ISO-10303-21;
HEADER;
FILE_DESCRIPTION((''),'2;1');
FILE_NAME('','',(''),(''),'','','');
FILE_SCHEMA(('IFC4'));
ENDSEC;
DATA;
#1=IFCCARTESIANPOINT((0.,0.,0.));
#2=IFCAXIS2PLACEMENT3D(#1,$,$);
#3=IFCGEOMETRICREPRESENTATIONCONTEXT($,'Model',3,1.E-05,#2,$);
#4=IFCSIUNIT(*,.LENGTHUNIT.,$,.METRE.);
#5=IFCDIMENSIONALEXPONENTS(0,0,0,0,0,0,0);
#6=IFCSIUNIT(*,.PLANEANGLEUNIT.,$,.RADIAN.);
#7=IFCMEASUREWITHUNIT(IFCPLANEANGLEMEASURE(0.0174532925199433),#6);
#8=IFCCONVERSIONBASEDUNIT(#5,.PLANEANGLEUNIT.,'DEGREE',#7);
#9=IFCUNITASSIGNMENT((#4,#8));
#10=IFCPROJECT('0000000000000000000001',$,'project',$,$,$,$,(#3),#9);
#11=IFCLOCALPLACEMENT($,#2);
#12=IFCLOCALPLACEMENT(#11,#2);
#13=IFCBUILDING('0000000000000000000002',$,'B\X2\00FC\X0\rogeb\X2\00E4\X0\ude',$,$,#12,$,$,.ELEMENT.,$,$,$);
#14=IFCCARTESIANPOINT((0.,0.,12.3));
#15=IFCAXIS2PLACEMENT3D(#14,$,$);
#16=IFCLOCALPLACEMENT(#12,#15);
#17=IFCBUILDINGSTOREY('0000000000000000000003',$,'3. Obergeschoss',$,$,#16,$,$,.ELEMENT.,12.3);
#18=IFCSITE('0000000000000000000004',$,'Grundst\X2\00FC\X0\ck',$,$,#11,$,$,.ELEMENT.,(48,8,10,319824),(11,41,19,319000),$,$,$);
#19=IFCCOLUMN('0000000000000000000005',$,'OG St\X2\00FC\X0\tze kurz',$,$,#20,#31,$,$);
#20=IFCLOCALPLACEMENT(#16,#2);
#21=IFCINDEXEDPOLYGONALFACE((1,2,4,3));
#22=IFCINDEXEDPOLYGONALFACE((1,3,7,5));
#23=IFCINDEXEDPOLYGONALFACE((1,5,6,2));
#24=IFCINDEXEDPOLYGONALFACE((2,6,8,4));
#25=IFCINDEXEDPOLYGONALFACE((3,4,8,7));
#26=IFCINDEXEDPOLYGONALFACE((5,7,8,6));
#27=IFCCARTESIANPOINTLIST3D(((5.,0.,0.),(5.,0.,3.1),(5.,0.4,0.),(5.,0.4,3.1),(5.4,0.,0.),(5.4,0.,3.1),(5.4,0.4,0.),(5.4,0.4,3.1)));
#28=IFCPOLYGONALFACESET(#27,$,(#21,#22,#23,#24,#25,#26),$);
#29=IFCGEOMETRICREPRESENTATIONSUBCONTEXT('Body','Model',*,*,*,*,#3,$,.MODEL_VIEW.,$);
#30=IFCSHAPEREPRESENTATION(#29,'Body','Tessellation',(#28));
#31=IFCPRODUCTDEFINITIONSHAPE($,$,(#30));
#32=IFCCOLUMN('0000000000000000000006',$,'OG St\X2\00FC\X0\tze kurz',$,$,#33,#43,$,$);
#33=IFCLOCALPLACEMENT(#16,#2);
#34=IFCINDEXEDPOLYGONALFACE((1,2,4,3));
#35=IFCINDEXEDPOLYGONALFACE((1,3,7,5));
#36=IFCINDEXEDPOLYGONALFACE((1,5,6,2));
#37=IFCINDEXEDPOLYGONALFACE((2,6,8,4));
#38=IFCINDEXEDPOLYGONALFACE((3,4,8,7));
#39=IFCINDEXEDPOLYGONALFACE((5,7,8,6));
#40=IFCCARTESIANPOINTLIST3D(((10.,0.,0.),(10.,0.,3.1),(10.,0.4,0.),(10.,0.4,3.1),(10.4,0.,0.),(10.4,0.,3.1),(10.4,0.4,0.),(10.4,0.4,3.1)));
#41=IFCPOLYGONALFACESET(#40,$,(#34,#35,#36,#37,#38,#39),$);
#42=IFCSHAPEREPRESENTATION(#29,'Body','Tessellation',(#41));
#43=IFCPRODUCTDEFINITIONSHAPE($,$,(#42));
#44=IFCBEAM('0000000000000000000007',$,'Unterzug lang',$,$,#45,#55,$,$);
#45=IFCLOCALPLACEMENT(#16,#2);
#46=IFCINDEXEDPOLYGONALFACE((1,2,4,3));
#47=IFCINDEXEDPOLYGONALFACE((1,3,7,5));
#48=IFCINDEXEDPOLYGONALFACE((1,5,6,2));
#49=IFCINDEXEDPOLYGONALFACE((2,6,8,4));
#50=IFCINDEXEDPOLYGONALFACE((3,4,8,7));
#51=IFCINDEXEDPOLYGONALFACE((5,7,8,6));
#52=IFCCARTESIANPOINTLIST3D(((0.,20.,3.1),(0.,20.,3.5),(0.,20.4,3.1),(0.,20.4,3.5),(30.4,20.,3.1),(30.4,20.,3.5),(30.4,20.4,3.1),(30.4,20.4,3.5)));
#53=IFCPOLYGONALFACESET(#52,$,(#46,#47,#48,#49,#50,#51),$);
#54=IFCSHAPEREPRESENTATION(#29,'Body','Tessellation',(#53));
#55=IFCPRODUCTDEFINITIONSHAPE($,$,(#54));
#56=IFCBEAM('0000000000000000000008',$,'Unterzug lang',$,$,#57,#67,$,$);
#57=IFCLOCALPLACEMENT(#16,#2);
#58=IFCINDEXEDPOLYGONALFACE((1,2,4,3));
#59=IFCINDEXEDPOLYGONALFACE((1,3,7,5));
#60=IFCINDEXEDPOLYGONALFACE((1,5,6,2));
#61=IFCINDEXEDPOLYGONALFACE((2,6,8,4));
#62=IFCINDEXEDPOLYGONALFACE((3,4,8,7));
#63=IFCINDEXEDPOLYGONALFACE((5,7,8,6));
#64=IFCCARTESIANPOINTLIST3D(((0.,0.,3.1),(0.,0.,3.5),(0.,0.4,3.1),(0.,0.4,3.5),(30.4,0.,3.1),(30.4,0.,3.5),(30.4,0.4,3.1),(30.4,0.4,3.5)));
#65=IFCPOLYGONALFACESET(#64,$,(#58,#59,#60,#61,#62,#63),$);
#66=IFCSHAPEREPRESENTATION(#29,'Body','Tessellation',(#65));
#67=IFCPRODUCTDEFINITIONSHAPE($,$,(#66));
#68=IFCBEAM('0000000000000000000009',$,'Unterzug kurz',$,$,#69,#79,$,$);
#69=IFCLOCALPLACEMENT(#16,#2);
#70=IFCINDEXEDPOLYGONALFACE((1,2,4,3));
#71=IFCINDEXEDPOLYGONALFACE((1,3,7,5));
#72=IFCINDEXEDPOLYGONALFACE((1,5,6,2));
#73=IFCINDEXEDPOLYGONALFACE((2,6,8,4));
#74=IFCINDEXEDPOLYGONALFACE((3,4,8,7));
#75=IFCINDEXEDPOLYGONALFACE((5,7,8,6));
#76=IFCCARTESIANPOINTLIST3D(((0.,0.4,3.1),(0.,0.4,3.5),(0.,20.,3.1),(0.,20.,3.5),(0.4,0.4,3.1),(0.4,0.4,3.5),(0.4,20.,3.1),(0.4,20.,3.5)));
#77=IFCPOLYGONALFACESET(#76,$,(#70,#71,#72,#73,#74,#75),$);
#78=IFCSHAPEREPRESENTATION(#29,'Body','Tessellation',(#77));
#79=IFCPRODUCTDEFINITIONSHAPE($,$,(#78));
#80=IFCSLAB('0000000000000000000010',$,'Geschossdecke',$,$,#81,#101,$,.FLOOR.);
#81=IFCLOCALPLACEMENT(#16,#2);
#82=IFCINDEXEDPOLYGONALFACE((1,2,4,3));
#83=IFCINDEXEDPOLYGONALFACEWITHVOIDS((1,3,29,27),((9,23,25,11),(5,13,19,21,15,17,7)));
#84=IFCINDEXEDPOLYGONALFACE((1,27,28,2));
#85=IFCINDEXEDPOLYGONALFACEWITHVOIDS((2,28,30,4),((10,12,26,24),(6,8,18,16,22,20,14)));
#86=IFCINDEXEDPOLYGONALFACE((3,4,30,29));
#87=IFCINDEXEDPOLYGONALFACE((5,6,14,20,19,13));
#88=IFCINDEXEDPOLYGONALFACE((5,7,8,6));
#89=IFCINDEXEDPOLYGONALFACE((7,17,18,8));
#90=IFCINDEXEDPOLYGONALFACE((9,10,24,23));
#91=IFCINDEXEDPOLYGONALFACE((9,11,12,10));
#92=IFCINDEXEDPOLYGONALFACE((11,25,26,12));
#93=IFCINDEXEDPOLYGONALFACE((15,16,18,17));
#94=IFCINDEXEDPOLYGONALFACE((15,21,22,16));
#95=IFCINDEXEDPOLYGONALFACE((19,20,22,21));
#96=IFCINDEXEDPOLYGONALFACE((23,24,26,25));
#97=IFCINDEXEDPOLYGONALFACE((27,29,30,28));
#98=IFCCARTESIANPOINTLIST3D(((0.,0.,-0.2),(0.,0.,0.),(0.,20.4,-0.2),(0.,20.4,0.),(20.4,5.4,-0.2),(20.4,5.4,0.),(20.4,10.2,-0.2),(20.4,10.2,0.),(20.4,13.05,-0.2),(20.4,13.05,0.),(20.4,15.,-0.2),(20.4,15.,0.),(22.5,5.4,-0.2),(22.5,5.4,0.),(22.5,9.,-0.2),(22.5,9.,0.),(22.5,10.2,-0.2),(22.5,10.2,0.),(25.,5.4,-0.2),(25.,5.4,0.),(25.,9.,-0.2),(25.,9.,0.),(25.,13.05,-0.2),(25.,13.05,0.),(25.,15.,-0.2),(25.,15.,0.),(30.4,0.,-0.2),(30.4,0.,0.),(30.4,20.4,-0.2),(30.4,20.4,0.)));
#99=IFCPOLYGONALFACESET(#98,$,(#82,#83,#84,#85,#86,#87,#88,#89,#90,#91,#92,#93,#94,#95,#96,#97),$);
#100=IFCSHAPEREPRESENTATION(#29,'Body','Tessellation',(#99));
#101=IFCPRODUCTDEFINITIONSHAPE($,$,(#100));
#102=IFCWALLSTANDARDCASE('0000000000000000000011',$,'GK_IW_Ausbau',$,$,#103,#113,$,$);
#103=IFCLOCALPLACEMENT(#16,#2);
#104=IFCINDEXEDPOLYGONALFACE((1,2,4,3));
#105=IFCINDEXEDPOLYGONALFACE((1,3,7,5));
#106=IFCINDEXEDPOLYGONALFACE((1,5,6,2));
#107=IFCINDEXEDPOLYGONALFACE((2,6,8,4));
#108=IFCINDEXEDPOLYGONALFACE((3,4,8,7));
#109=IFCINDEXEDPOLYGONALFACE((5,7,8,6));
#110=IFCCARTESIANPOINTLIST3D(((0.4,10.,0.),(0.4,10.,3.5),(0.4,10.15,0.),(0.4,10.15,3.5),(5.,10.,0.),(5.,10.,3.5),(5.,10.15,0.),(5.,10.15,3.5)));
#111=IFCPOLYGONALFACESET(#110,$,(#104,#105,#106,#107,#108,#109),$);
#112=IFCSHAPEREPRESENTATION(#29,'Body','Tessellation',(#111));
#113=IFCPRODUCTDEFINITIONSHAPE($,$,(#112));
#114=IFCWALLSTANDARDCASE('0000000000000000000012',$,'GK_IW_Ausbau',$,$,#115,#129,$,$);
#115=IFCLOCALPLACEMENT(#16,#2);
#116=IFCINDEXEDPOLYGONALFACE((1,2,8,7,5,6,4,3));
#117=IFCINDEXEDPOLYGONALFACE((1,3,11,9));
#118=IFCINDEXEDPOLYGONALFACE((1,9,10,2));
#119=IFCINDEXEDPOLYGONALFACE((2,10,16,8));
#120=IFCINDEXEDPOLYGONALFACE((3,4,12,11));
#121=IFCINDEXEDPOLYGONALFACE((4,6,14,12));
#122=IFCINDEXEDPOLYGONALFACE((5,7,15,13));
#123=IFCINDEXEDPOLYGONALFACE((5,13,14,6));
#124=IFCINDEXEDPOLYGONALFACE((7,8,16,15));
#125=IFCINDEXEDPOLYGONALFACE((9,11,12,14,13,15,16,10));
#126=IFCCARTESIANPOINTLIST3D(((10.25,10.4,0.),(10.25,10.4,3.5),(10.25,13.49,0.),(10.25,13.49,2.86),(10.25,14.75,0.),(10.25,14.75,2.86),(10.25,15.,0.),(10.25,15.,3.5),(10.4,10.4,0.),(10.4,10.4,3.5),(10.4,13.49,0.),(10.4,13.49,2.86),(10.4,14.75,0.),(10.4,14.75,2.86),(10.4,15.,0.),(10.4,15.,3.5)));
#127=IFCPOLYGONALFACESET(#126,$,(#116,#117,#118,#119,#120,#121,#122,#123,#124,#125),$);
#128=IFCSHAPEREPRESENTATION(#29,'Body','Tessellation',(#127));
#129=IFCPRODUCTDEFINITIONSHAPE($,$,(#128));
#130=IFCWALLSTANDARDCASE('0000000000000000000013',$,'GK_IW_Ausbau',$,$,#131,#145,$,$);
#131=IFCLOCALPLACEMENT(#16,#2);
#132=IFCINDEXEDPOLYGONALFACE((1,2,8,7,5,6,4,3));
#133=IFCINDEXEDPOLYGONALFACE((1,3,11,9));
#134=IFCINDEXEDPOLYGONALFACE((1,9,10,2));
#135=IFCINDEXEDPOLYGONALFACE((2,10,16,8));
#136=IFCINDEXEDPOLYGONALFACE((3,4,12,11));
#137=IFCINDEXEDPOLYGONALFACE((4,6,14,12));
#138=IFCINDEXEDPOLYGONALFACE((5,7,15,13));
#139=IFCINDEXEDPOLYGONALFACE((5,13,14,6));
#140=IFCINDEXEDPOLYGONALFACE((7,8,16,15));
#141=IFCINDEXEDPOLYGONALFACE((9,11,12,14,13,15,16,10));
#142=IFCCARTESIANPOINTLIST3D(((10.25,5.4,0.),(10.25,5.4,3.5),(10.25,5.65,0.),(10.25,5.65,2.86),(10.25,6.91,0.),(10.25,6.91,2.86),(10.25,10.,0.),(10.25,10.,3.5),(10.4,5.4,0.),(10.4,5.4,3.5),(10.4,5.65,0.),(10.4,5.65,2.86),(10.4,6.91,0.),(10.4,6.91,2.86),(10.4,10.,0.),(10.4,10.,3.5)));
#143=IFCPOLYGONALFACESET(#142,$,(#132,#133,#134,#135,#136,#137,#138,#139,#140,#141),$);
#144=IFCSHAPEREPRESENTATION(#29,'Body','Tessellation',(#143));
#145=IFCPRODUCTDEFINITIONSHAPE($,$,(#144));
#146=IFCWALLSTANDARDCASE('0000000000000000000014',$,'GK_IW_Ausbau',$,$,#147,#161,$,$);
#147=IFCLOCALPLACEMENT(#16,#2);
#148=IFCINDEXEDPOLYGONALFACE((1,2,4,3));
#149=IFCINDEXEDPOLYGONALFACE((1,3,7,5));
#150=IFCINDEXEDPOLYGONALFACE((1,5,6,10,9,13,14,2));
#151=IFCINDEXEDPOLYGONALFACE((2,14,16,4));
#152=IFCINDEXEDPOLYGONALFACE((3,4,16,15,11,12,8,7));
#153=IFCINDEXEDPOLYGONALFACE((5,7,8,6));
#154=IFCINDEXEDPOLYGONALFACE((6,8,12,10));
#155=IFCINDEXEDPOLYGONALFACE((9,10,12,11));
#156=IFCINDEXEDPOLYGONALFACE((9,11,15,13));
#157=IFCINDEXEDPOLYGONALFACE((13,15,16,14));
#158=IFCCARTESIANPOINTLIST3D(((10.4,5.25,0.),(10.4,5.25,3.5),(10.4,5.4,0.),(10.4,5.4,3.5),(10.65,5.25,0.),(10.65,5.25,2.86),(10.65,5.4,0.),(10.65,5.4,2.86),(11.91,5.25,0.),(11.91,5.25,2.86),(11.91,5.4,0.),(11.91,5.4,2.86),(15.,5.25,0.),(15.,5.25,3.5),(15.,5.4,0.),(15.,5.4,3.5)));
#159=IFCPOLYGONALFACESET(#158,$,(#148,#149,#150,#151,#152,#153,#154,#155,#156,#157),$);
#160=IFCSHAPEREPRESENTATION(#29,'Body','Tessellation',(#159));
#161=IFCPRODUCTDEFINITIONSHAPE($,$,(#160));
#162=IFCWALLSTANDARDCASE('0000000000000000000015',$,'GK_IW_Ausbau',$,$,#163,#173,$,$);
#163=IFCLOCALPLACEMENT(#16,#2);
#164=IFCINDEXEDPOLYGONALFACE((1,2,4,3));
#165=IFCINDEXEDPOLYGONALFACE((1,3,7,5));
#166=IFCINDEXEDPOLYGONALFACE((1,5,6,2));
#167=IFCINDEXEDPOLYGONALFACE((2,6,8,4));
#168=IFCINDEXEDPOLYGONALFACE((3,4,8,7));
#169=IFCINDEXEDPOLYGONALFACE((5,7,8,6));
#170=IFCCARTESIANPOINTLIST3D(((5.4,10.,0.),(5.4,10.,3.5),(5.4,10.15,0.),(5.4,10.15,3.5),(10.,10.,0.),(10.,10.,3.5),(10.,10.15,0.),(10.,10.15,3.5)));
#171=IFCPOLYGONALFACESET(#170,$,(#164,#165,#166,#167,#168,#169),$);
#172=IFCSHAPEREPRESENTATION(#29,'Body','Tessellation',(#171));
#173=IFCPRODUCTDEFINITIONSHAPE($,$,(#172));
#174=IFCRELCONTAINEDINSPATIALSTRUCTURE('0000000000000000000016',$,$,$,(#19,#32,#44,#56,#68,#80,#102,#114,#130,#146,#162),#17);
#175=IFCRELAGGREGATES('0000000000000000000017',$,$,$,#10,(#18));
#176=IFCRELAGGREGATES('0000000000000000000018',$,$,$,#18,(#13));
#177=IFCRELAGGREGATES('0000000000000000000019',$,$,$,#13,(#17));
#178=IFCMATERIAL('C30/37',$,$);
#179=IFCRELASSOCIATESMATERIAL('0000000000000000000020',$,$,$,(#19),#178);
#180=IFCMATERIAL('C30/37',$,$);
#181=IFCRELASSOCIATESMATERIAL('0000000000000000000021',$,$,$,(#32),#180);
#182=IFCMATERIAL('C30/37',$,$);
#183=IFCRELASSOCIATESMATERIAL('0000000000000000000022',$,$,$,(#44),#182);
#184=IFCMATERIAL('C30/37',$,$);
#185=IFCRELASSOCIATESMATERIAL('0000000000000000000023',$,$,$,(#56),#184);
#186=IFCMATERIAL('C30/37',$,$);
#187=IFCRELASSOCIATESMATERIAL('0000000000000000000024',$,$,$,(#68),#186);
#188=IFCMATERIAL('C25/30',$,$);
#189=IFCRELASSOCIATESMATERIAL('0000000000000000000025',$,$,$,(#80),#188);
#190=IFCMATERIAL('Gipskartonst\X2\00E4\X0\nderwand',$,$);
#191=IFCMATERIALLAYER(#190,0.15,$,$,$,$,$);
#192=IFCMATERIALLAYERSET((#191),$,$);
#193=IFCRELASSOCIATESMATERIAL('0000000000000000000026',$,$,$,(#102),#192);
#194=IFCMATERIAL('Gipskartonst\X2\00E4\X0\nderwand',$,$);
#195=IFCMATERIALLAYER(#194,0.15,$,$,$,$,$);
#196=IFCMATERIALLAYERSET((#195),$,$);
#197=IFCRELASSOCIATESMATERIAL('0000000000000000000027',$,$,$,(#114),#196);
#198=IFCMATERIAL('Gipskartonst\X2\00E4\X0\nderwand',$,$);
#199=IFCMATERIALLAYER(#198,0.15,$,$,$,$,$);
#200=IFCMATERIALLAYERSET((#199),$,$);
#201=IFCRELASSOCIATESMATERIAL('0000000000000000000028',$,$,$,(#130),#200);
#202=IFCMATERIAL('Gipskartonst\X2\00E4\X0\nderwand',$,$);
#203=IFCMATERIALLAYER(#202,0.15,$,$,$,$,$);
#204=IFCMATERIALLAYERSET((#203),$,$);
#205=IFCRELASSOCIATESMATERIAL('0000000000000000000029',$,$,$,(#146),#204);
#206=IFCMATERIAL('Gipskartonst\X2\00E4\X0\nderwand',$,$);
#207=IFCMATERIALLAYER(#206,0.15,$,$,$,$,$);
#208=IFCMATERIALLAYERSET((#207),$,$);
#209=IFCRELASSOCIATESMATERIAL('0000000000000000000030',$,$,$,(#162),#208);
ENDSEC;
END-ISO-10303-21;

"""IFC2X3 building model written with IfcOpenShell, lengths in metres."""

from ifc_helpers import new_model, entity, si_unit, converted_unit, frame, frame_2d, origin, origin_with_axes, place, context, subcontext, project, spatial, polyline, rectangle, outline, extrude, material, layer, layer_set, layer_usage, element, save


model = new_model("IFC2X3")

# Units and contexts
model_context = context("Model", 3, precision=1e-05, world=origin())
body_context = subcontext(model_context, "Body", "Model", "MODEL_VIEW")
ifc_project = project(units=[si_unit("LENGTHUNIT", "METRE"), converted_unit("PLANEANGLEUNIT", "DEGREE", entity("IfcPlaneAngleMeasure", 0.0174532925199433), si_unit("PLANEANGLEUNIT", "RADIAN"), dimensions=[0, 0, 0, 0, 0, 0, 0])], contexts=[model_context])

# Site, building, storey
site_placement = place(None, origin())
site = spatial("IfcSite", under=ifc_project, at=site_placement, Name="Grundstück", CompositionType="ELEMENT", RefLatitude=(48, 8, 10, 319824), RefLongitude=(11, 41, 19, 319000))
building_placement = place(site_placement, origin())
building = spatial("IfcBuilding", under=site, at=building_placement, Name="Bürogebäude", CompositionType="ELEMENT")
storey_placement = place(building_placement, frame((0.0, 0.0, 12.3)))
storey = spatial("IfcBuildingStorey", under=building, at=storey_placement, Name="3. Obergeschoss", CompositionType="ELEMENT", Elevation=12.3)

# Columns
ifc_material_1 = material(Name="C30/37")
column_1_placement = place(storey_placement, frame((5.0, 0.0, 0.0)))
element("IfcColumn", 1, at=column_1_placement, inside=storey, material=ifc_material_1, Name="OG Stütze kurz", context=body_context, shape_type="SweptSolid", body=[
    extrude(rectangle(XDim=0.4, YDim=0.4, at=frame_2d((0.2, 0.2), x_axis=(1.0, 0.0))), origin_with_axes(), (0.0, 0.0, 1.0), 3.1),
])
ifc_material_2 = material(Name="C30/37")
column_2_placement = place(storey_placement, frame((10.0, 0.0, 0.0)))
element("IfcColumn", 2, at=column_2_placement, inside=storey, material=ifc_material_2, Name="OG Stütze kurz", context=body_context, shape_type="SweptSolid", body=[
    extrude(rectangle(XDim=0.4, YDim=0.4, at=frame_2d((0.2, 0.2), x_axis=(1.0, 0.0))), origin_with_axes(), (0.0, 0.0, 1.0), 3.1),
])

# Beams
ifc_material_3 = material(Name="C30/37")
beam_1_placement = place(storey_placement, frame((0.0, 20.0, 3.1)))
element("IfcBeam", 3, at=beam_1_placement, inside=storey, material=ifc_material_3, Name="Unterzug lang", context=body_context, shape_type="SweptSolid", body=[
    extrude(rectangle(XDim=0.4, YDim=0.4, at=frame_2d((0.2, 0.2), x_axis=(1.0, 0.0))), frame((0.0, 0.0, 0.0), z_axis=(1.0, 0.0, 0.0), x_axis=(0.0, 1.0, 0.0)), (0.0, 0.0, 1.0), 30.4),
])
ifc_material_4 = material(Name="C30/37")
beam_2_placement = place(storey_placement, frame((0.0, 0.0, 3.1), z_axis=(0.0, 0.0, 1.0), x_axis=(1.0, 0.0, 0.0)))
element("IfcBeam", 4, at=beam_2_placement, inside=storey, material=ifc_material_4, Name="Unterzug lang", context=body_context, shape_type="SweptSolid", body=[
    extrude(rectangle(XDim=0.4, YDim=0.4, at=frame_2d((0.2, 0.2), x_axis=(1.0, 0.0))), frame((0.0, 0.0, 0.0), z_axis=(1.0, 0.0, 0.0), x_axis=(0.0, 1.0, 0.0)), (0.0, 0.0, 1.0), 30.4),
])
ifc_material_5 = material(Name="C30/37")
beam_3_placement = place(storey_placement, frame((0.0, 20.0, 3.1), z_axis=(0.0, 0.0, 1.0), x_axis=(0.0, -1.0, 0.0)))
element("IfcBeam", 5, at=beam_3_placement, inside=storey, material=ifc_material_5, Name="Unterzug kurz", context=body_context, shape_type="SweptSolid", body=[
    extrude(rectangle(XDim=0.4, YDim=0.4, at=frame_2d((0.2, 0.2), x_axis=(1.0, 0.0))), frame((0.0, 0.0, 0.0), z_axis=(1.0, 0.0, 0.0), x_axis=(0.0, 1.0, 0.0)), (0.0, 0.0, 1.0), 19.6),
])

# Slab, openings
ifc_material_6 = material(Name="C25/30")
slab_placement = place(storey_placement, frame((0.0, 0.0, -0.2)))
slab = element("IfcSlab", 6, at=slab_placement, inside=storey, material=ifc_material_6, Name="Geschossdecke", PredefinedType="FLOOR", context=body_context, shape_type="SweptSolid", body=[
    extrude(rectangle(XDim=30.4, YDim=20.4, at=frame_2d((15.2, 10.2), x_axis=(1.0, 0.0))), origin_with_axes(), (0.0, 0.0, 1.0), 0.2),
])
opening_1_placement = place(slab_placement, frame((20.4, 5.4, 0.0)))
element("IfcOpeningElement", 7, at=opening_1_placement, cuts=slab, ObjectType="Opening", context=body_context, shape_type="SweptSolid", body=[
    extrude(rectangle(XDim=2.1, YDim=4.8, at=frame_2d((0.0, 0.0), x_axis=(1.0, 0.0))), frame((1.05, 2.4, 0.0), z_axis=(0.0, 0.0, 1.0), x_axis=(1.0, 0.0, 0.0)), (0.0, 0.0, 1.0), 0.2),
])
opening_2_placement = place(slab_placement, frame((22.5, 5.4, 0.0)))
element("IfcOpeningElement", 8, at=opening_2_placement, cuts=slab, ObjectType="Opening", context=body_context, shape_type="SweptSolid", body=[
    extrude(rectangle(XDim=2.5, YDim=3.6, at=frame_2d((0.0, 0.0), x_axis=(-1.0, 0.0))), frame((1.25, 1.8, 0.0), z_axis=(0.0, 0.0, 1.0), x_axis=(1.0, 0.0, 0.0)), (0.0, 0.0, 1.0), 0.2),
])
opening_3_placement = place(slab_placement, frame((20.4, 13.05, 0.0)))
element("IfcOpeningElement", 9, at=opening_3_placement, cuts=slab, ObjectType="Opening", context=body_context, shape_type="SweptSolid", body=[
    extrude(rectangle(XDim=1.95, YDim=4.6, at=frame_2d((0.0, 0.0), x_axis=(0.0, -1.0))), frame((2.3, 0.975, 0.0), z_axis=(0.0, 0.0, 1.0), x_axis=(1.0, 0.0, 0.0)), (0.0, 0.0, 1.0), 0.2),
])

# Wall
ifc_material_7 = material(Name="Gipskartonständerwand")
ifc_layer_1 = layer(ifc_material_7, 0.15)
ifc_layer_set_1 = layer_set([ifc_layer_1])
ifc_layer_usage_1 = layer_usage(ifc_layer_set_1, "AXIS2", "POSITIVE", -0.15)
wall_1_placement = place(storey_placement, frame((5.0, 10.15, 0.0), z_axis=(0.0, 0.0, 1.0), x_axis=(-1.0, 0.0, 0.0)))
element("IfcWallStandardCase", 10, at=wall_1_placement, inside=storey, material=ifc_layer_usage_1, Name="GK_IW_Ausbau", context=body_context, shape_type="SweptSolid", body=[
    extrude(rectangle(XDim=4.6, YDim=0.15, at=frame_2d((2.3, 0.075), x_axis=(1.0, 0.0))), origin_with_axes(), (0.0, 0.0, 1.0), 3.5),
])

# Walls, openings
ifc_material_8 = material(Name="Gipskartonständerwand")
ifc_layer_2 = layer(ifc_material_8, 0.15)
ifc_layer_set_2 = layer_set([ifc_layer_2])
ifc_layer_usage_2 = layer_usage(ifc_layer_set_2, "AXIS2", "POSITIVE", -0.15)
wall_2_placement = place(storey_placement, frame((10.25, 15.0, 0.0), z_axis=(0.0, 0.0, 1.0), x_axis=(0.0, -1.0, 0.0)))
wall_2 = element("IfcWallStandardCase", 11, at=wall_2_placement, inside=storey, material=ifc_layer_usage_2, Name="GK_IW_Ausbau", context=body_context, shape_type="SweptSolid", body=[
    extrude(rectangle(XDim=4.6, YDim=0.15, at=frame_2d((2.3, 0.075), x_axis=(1.0, 0.0))), origin_with_axes(), (0.0, 0.0, 1.0), 3.5),
])
opening_4_placement = place(wall_2_placement, frame((1.51, 0.15, 0.0), z_axis=(0.0, -1.0, 0.0), x_axis=(0.0, 0.0, 1.0)))
element("IfcOpeningElement", 12, at=opening_4_placement, cuts=wall_2, ObjectType="Opening", context=body_context, shape_type="SweptSolid", body=[
    extrude(outline(polyline([(0.0, 1.26), (2.86, 1.26), (2.86, 0.0), (0.0, 0.0), (0.0, 1.26)])), origin_with_axes(), (0.0, 0.0, 1.0), 0.15),
])
ifc_material_9 = material(Name="Gipskartonständerwand")
ifc_layer_3 = layer(ifc_material_9, 0.15)
ifc_layer_set_3 = layer_set([ifc_layer_3])
ifc_layer_usage_3 = layer_usage(ifc_layer_set_3, "AXIS2", "POSITIVE", -0.15)
wall_3_placement = place(storey_placement, frame((10.25, 10.0, 0.0), z_axis=(0.0, 0.0, 1.0), x_axis=(0.0, -1.0, 0.0)))
wall_3 = element("IfcWallStandardCase", 13, at=wall_3_placement, inside=storey, material=ifc_layer_usage_3, Name="GK_IW_Ausbau", context=body_context, shape_type="SweptSolid", body=[
    extrude(rectangle(XDim=4.6, YDim=0.15, at=frame_2d((2.3, 0.075), x_axis=(1.0, 0.0))), origin_with_axes(), (0.0, 0.0, 1.0), 3.5),
])
opening_5_placement = place(wall_3_placement, frame((4.35, 0.15, 0.0), z_axis=(0.0, -1.0, 0.0), x_axis=(0.0, 0.0, 1.0)))
element("IfcOpeningElement", 14, at=opening_5_placement, cuts=wall_3, ObjectType="Opening", context=body_context, shape_type="SweptSolid", body=[
    extrude(outline(polyline([(0.0, 1.26), (2.86, 1.26), (2.86, 0.0), (0.0, 0.0), (0.0, 1.26)])), origin_with_axes(), (0.0, 0.0, 1.0), 0.15),
])
ifc_material_10 = material(Name="Gipskartonständerwand")
ifc_layer_4 = layer(ifc_material_10, 0.15)
ifc_layer_set_4 = layer_set([ifc_layer_4])
ifc_layer_usage_4 = layer_usage(ifc_layer_set_4, "AXIS2", "POSITIVE", -0.15)
wall_4_placement = place(storey_placement, frame((10.4, 5.25, 0.0)))
wall_4 = element("IfcWallStandardCase", 15, at=wall_4_placement, inside=storey, material=ifc_layer_usage_4, Name="GK_IW_Ausbau", context=body_context, shape_type="SweptSolid", body=[
    extrude(rectangle(XDim=4.6, YDim=0.15, at=frame_2d((2.3, 0.075), x_axis=(1.0, 0.0))), origin_with_axes(), (0.0, 0.0, 1.0), 3.5),
])
opening_6_placement = place(wall_4_placement, frame((1.51, 0.15, 0.0), z_axis=(0.0, -1.0, 0.0), x_axis=(0.0, 0.0, 1.0)))
element("IfcOpeningElement", 16, at=opening_6_placement, cuts=wall_4, ObjectType="Opening", context=body_context, shape_type="SweptSolid", body=[
    extrude(outline(polyline([(0.0, 1.26), (2.86, 1.26), (2.86, 0.0), (0.0, 0.0), (0.0, 1.26)])), origin_with_axes(), (0.0, 0.0, 1.0), 0.15),
])

# Wall
ifc_material_11 = material(Name="Gipskartonständerwand")
ifc_layer_5 = layer(ifc_material_11, 0.15)
ifc_layer_set_5 = layer_set([ifc_layer_5])
ifc_layer_usage_5 = layer_usage(ifc_layer_set_5, "AXIS2", "POSITIVE", -0.15)
wall_5_placement = place(storey_placement, frame((10.0, 10.15, 0.0), z_axis=(0.0, 0.0, 1.0), x_axis=(-1.0, 0.0, 0.0)))
element("IfcWallStandardCase", 17, at=wall_5_placement, inside=storey, material=ifc_layer_usage_5, Name="GK_IW_Ausbau", context=body_context, shape_type="SweptSolid", body=[
    extrude(rectangle(XDim=4.6, YDim=0.15, at=frame_2d((2.3, 0.075), x_axis=(1.0, 0.0))), origin_with_axes(), (0.0, 0.0, 1.0), 3.5),
])

save(model, "model.ifc")
